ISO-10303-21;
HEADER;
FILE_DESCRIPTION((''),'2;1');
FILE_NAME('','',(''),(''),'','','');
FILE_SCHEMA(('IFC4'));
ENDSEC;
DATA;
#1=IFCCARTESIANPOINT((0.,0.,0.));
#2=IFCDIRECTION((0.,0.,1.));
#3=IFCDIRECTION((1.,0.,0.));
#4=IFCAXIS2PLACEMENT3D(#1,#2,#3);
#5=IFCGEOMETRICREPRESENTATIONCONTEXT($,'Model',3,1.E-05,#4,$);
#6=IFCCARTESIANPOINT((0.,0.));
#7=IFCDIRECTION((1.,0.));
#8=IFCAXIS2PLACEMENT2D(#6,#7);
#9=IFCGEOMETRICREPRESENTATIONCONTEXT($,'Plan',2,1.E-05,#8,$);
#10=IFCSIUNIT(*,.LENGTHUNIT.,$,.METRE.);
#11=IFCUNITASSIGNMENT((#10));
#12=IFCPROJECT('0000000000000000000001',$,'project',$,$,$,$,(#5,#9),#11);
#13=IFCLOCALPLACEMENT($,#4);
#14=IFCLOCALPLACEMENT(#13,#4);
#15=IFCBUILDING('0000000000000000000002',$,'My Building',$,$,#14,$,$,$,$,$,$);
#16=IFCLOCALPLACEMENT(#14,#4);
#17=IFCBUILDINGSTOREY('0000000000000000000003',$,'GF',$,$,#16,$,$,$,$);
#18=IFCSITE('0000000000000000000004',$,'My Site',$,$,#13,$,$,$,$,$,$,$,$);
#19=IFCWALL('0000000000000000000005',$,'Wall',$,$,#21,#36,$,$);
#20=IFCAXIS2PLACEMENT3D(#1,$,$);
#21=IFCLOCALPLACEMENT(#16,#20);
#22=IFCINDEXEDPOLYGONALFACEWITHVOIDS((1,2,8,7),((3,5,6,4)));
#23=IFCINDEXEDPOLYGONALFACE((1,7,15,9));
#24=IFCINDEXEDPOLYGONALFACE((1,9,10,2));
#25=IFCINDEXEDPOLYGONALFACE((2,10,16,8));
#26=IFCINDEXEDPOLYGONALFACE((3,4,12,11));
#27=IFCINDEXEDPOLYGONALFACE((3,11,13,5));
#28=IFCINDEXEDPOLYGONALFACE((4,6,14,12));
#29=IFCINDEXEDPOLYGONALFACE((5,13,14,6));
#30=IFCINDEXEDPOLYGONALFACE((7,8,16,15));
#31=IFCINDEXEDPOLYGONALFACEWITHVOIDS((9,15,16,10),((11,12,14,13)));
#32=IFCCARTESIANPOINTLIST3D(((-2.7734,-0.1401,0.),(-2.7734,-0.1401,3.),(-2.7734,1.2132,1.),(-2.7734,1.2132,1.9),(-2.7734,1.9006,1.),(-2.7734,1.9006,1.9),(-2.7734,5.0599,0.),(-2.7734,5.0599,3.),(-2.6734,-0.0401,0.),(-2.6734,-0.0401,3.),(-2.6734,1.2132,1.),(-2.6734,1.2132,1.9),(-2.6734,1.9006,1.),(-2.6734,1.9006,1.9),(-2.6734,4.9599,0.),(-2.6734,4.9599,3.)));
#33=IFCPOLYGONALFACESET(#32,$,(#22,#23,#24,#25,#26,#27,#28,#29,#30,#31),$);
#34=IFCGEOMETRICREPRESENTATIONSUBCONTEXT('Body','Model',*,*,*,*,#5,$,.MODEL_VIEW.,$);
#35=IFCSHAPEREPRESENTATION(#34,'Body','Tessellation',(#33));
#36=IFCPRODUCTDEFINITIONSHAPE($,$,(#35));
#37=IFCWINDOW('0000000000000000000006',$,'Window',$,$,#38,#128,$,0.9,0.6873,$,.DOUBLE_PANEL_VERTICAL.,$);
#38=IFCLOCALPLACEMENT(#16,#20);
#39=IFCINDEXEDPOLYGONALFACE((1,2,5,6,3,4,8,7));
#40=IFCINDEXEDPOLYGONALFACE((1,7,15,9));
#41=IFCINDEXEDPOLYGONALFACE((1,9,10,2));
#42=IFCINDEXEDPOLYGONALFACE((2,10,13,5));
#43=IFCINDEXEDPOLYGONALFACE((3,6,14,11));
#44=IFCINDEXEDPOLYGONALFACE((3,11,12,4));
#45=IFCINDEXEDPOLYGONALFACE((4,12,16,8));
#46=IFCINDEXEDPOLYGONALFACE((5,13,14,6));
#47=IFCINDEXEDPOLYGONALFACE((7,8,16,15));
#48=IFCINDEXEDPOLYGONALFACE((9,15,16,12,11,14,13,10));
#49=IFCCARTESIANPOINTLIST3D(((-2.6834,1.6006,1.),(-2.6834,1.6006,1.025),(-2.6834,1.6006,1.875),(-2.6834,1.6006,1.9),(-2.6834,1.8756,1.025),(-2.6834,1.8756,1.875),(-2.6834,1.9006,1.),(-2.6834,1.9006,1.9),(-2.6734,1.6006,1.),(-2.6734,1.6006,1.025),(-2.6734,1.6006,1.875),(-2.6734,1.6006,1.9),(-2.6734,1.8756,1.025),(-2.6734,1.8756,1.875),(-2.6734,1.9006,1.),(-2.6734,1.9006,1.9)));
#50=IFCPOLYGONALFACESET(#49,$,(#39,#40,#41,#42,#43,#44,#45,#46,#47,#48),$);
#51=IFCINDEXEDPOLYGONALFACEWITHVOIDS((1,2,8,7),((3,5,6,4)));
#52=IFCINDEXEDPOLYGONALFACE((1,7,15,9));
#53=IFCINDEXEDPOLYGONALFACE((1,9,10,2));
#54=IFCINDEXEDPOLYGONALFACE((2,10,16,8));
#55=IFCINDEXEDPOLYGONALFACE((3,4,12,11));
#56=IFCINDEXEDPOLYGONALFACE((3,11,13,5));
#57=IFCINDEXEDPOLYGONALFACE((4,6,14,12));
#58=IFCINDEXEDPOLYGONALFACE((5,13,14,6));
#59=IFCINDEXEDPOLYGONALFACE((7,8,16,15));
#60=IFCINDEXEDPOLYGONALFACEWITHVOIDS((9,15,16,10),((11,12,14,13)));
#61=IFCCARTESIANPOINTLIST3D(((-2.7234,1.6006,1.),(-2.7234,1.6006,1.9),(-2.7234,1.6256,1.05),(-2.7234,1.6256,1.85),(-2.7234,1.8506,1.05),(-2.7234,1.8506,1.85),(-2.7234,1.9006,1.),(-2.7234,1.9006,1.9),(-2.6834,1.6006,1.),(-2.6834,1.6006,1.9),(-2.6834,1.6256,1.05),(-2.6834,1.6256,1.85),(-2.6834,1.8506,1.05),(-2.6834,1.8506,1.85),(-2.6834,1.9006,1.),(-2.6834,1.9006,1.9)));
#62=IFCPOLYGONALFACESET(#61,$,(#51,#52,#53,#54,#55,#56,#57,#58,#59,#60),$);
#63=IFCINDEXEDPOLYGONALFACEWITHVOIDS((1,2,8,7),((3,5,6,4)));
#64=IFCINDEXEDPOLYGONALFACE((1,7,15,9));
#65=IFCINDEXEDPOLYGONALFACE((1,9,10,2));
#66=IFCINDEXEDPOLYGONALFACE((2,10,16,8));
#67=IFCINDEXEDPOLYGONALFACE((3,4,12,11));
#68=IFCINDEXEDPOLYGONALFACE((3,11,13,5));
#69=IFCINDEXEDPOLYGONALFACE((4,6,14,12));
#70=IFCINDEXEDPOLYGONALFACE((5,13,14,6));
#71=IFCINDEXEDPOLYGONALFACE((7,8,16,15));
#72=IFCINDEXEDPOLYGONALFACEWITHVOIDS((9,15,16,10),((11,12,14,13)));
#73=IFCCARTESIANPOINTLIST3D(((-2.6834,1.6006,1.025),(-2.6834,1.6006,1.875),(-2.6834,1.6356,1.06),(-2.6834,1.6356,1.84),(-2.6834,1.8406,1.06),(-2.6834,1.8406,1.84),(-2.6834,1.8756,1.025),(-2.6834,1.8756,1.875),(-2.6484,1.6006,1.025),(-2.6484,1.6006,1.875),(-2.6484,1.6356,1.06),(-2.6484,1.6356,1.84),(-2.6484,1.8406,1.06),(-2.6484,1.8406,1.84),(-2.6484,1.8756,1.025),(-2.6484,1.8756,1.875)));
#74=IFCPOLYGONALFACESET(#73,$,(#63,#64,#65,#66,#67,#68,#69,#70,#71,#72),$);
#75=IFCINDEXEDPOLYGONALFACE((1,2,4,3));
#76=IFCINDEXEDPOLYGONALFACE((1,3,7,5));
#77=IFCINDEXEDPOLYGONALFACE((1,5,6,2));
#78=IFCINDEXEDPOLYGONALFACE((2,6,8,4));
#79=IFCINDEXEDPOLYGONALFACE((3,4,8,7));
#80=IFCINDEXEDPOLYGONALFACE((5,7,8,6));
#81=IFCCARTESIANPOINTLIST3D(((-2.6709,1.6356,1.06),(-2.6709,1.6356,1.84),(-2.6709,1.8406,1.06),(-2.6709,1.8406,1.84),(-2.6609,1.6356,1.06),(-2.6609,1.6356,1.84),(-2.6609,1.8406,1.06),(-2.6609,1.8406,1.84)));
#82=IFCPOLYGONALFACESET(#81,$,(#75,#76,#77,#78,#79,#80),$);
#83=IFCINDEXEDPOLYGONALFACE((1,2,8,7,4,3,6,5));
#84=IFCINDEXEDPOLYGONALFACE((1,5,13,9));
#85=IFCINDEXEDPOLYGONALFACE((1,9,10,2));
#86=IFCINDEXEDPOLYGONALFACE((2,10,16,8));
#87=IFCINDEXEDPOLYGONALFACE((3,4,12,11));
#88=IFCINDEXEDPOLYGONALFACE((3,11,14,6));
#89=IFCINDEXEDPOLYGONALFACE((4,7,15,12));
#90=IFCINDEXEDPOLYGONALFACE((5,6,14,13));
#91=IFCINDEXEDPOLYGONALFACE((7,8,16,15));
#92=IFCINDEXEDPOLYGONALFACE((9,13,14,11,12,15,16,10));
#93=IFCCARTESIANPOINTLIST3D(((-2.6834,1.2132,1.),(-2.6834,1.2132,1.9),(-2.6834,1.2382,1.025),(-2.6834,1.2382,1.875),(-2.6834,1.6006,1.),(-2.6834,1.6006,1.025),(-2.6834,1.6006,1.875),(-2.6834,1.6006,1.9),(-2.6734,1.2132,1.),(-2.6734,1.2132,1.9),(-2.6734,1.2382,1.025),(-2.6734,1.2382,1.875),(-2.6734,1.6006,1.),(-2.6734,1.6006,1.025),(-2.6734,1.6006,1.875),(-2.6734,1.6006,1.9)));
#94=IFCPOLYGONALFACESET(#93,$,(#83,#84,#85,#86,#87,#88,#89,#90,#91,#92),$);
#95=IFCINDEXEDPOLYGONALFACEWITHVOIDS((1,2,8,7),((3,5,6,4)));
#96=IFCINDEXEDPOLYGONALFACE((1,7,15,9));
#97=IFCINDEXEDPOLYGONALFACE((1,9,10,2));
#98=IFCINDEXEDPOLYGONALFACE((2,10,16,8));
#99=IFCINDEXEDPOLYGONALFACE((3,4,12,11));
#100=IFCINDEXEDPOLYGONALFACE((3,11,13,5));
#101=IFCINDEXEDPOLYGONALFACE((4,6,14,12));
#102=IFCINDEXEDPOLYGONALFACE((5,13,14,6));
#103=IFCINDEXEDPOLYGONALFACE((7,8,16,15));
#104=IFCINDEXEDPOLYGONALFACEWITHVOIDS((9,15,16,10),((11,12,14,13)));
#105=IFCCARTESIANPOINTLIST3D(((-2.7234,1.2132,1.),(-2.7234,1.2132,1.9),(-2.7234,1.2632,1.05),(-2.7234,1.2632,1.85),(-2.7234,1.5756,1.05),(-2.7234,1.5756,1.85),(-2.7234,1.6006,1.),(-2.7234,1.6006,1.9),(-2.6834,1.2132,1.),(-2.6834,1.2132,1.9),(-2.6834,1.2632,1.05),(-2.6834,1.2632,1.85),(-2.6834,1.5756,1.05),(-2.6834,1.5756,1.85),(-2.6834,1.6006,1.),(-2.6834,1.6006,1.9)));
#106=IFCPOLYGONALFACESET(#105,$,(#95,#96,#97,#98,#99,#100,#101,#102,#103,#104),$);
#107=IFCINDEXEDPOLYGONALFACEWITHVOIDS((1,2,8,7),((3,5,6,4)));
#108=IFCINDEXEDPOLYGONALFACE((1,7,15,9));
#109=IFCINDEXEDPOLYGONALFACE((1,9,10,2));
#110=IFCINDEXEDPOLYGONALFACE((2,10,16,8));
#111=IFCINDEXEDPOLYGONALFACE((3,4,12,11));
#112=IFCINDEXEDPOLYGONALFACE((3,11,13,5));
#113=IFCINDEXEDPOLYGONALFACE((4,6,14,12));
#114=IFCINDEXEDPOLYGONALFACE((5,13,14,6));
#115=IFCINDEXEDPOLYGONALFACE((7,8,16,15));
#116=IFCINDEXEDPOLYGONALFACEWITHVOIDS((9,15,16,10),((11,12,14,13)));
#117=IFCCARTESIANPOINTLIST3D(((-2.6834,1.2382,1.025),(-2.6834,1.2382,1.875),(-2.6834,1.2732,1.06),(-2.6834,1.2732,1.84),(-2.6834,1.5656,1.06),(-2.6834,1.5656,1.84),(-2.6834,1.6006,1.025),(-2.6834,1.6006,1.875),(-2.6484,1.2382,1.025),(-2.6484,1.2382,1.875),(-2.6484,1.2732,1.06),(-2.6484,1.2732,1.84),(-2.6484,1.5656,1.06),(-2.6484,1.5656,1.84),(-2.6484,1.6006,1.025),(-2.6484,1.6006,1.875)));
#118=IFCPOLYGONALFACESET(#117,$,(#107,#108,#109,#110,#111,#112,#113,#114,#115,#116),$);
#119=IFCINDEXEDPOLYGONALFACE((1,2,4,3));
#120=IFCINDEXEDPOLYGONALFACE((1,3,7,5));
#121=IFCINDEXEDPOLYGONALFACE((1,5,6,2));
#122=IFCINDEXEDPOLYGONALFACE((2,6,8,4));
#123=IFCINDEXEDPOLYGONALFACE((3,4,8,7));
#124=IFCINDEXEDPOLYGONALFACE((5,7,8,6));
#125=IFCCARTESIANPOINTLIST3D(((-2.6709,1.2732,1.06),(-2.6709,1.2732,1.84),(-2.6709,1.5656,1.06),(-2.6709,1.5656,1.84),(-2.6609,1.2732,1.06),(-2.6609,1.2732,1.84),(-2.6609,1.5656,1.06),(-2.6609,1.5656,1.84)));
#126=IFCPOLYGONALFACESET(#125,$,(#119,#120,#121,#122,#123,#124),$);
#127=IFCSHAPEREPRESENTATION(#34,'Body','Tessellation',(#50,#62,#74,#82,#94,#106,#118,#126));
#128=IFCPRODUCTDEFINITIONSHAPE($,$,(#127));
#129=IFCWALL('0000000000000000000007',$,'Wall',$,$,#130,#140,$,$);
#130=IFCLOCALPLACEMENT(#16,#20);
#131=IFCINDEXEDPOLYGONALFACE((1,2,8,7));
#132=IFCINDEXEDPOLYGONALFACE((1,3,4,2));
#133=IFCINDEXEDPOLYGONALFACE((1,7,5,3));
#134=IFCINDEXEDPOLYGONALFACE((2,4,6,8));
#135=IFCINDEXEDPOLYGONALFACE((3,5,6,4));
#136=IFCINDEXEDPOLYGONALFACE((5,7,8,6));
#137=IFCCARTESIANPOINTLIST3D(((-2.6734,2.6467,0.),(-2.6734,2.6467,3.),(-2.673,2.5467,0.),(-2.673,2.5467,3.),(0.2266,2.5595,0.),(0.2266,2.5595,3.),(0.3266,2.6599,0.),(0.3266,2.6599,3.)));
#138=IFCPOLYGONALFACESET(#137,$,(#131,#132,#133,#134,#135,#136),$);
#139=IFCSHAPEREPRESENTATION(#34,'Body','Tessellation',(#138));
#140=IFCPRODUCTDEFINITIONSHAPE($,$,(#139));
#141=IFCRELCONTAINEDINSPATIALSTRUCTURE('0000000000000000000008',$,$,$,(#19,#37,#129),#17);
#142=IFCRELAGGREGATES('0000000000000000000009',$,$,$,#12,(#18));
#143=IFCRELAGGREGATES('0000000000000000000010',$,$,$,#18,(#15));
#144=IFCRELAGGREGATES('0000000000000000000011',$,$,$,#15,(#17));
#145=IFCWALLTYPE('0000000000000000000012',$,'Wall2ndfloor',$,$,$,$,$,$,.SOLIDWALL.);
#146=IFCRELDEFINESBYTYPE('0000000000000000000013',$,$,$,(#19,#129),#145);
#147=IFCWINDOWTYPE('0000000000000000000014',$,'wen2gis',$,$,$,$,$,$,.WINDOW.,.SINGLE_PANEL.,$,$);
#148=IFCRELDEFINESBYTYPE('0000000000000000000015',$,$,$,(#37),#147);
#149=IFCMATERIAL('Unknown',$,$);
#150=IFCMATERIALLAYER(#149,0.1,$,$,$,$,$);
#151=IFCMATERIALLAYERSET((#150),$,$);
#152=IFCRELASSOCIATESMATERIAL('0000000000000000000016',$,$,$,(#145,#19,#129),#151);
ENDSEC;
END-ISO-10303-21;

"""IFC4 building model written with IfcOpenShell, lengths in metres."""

from ifc_helpers import new_model, entity, si_unit, frame, origin_with_axes, origin_2d_with_axis, place, context, subcontext, project, spatial, line, indexed_curve, outline, extrude, shape, source, transform, mapped, material, layer, layer_set, layer_usage, type_object, type_shapes, element, fill, save


model = new_model("IFC4")

# Units and contexts
model_context = context("Model", 3, precision=1e-05, world=origin_with_axes())
plan_context = context("Plan", 2, precision=1e-05, world=origin_2d_with_axis())
body_context_1 = subcontext(model_context, "Body", "Model", "MODEL_VIEW")
body_context_2 = subcontext(plan_context, "Body", "Plan", "PLAN_VIEW")
ifc_project = project(units=[si_unit("LENGTHUNIT", "METRE")], contexts=[model_context, plan_context])

# Site, building, storey
site_placement = place(None, origin_with_axes())
site = spatial("IfcSite", under=ifc_project, at=site_placement, Name="My Site")
building_placement = place(site_placement, origin_with_axes())
building = spatial("IfcBuilding", under=site, at=building_placement, Name="My Building")
storey_placement = place(building_placement, origin_with_axes())
storey = spatial("IfcBuildingStorey", under=building, at=storey_placement, Name="GF")

# Shared definitions
ifc_material = material(Name="Unknown")

# Shared definitions
ifc_layer = layer(ifc_material, 0.1)
ifc_layer_set = layer_set([ifc_layer])
wall_type = type_object("IfcWallType", Name="Wall2ndfloor", PredefinedType="SOLIDWALL", material=ifc_layer_set)

# Wall, opening, window
ifc_layer_usage_1 = layer_usage(ifc_layer_set, "AXIS2", "POSITIVE", 0.0)
wall_1_placement = place(storey_placement, frame((-2.7734, 5.0599, 0.0), z_axis=(0.0, 0.0, 1.0), x_axis=(0.0, -1.0, 0.0)))
wall_1 = element("IfcWall", 1, at=wall_1_placement, inside=storey, type_object=wall_type, material=ifc_layer_usage_1, Name="Wall", context=body_context_1, shape_type="SweptSolid", body=[
    extrude(outline(indexed_curve([(0.0, 0.0), (0.1, 0.1), (5.1, 0.1), (5.2, 0.0)], segments=[line(1, 2, 3, 4, 1)])), origin_with_axes(), (0.0, 0.0, 1.0), 3.0),
])
shared_shape_1 = source(origin_with_axes(), body_context_1, "Body", "SweptSolid", [
    extrude(outline(indexed_curve([(0.0, 0.0), (0.6873, 0.0), (0.6873, 0.9), (0.0, 0.9)], segments=[line(1, 2, 3, 4, 1)])), frame((0.0, -0.6, 0.0), z_axis=(0.0, -1.0, 0.0), x_axis=(1.0, 0.0, 0.0)), (0.0, 0.0, -1.0), 1.2),
])
opening_1_placement = place(wall_1_placement, frame((3.1593, 0.0, 1.0), z_axis=(0.0, 0.0, 1.0), x_axis=(1.0, 0.0, 0.0)))
opening_1 = element("IfcOpeningElement", 2, at=opening_1_placement, cuts=wall_1, PredefinedType="OPENING", context=body_context_1, shape_type="MappedRepresentation", body=[
    mapped(shared_shape_1, transform((0.0, 0.0, 0.0), x_axis=(1.0, 0.0, 0.0), y_axis=(0.0, 1.0, 0.0), z_axis=(0.0, 0.0, 1.0), scale=1.0)),
])
window_type_1 = type_object("IfcWindowType", Name="wen2gis", PartitioningType="SINGLE_PANEL", PredefinedType="WINDOW")
shared_shape_2 = source(origin_with_axes(), body_context_1, "Body", "SweptSolid", [
    extrude(outline(indexed_curve([(0.3, 0.0), (0.0, 0.0), (0.0, 0.9), (0.3, 0.9), (0.3, 0.875), (0.025, 0.875), (0.025, 0.025), (0.3, 0.025)], segments=[line(1, 2, 3, 4, 5, 6, 7, 8, 1)])), frame((0.0, 0.09, 0.0), z_axis=(0.0, -1.0, 0.0), x_axis=(1.0, 0.0, 0.0)), (0.0, 0.0, -1.0), 0.01),
    extrude(outline(indexed_curve([(0.0, 0.0), (0.3, 0.0), (0.3, 0.9), (0.0, 0.9)], segments=[line(1, 2, 3, 4, 1)]), holes=[indexed_curve([(0.05, 0.05), (0.275, 0.05), (0.275, 0.85), (0.05, 0.85)], segments=[line(1, 2, 3, 4, 1)])]), frame((0.0, 0.05, 0.0), z_axis=(0.0, -1.0, 0.0), x_axis=(1.0, 0.0, 0.0)), (0.0, 0.0, -1.0), 0.04),
    extrude(outline(indexed_curve([(0.0, 0.0), (0.275, 0.0), (0.275, 0.85), (0.0, 0.85)], segments=[line(1, 2, 3, 4, 1)]), holes=[indexed_curve([(0.035, 0.035), (0.24, 0.035), (0.24, 0.815), (0.035, 0.815)], segments=[line(1, 2, 3, 4, 1)])]), frame((0.025, 0.09, 0.025), z_axis=(0.0, -1.0, 0.0), x_axis=(1.0, 0.0, 0.0)), (0.0, 0.0, -1.0), 0.035),
    extrude(outline(indexed_curve([(0.035, 0.035), (0.24, 0.035), (0.24, 0.815), (0.035, 0.815)], segments=[line(1, 2, 3, 4, 1)])), frame((0.025, 0.1025, 0.025), z_axis=(0.0, -1.0, 0.0), x_axis=(1.0, 0.0, 0.0)), (0.0, 0.0, -1.0), 0.01),
    extrude(outline(indexed_curve([(0.0, 0.9), (0.3873, 0.9), (0.3873, 0.0), (0.0, 0.0), (0.0, 0.025), (0.3623, 0.025), (0.3623, 0.875), (0.0, 0.875)], segments=[line(1, 2, 3, 4, 5, 6, 7, 8, 1)])), frame((0.3, 0.09, 0.0), z_axis=(0.0, -1.0, 0.0), x_axis=(1.0, 0.0, 0.0)), (0.0, 0.0, -1.0), 0.01),
    extrude(outline(indexed_curve([(0.0, 0.0), (0.3873, 0.0), (0.3873, 0.9), (0.0, 0.9)], segments=[line(1, 2, 3, 4, 1)]), holes=[indexed_curve([(0.025, 0.05), (0.3373, 0.05), (0.3373, 0.85), (0.025, 0.85)], segments=[line(1, 2, 3, 4, 1)])]), frame((0.3, 0.05, 0.0), z_axis=(0.0, -1.0, 0.0), x_axis=(1.0, 0.0, 0.0)), (0.0, 0.0, -1.0), 0.04),
    extrude(outline(indexed_curve([(0.0, 0.0), (0.3623, 0.0), (0.3623, 0.85), (0.0, 0.85)], segments=[line(1, 2, 3, 4, 1)]), holes=[indexed_curve([(0.035, 0.035), (0.3273, 0.035), (0.3273, 0.815), (0.035, 0.815)], segments=[line(1, 2, 3, 4, 1)])]), frame((0.3, 0.09, 0.025), z_axis=(0.0, -1.0, 0.0), x_axis=(1.0, 0.0, 0.0)), (0.0, 0.0, -1.0), 0.035),
    extrude(outline(indexed_curve([(0.035, 0.035), (0.3273, 0.035), (0.3273, 0.815), (0.035, 0.815)], segments=[line(1, 2, 3, 4, 1)])), frame((0.3, 0.1025, 0.025), z_axis=(0.0, -1.0, 0.0), x_axis=(1.0, 0.0, 0.0)), (0.0, 0.0, -1.0), 0.01),
])
shared_shape_3 = source(origin_with_axes(), body_context_2, "Body", "Curve2D", [
    entity("IfcIndexedPolyCurve", entity("IfcCartesianPointList2D", [[0.05, 0.05], [0.275, 0.05]])),
    entity("IfcIndexedPolyCurve", entity("IfcCartesianPointList2D", [[0.0, 0.1], [0.025, 0.1], [0.025, 0.09], [0.05, 0.09], [0.05, 0.05], [0.0, 0.05]]), [entity("IfcLineIndex", [1, 2, 3, 4, 5, 6, 1])]),
    entity("IfcIndexedPolyCurve", entity("IfcCartesianPointList2D", [[0.3, 0.1], [0.3, 0.1], [0.3, 0.09], [0.275, 0.09], [0.275, 0.05], [0.3, 0.05]])),
    entity("IfcIndexedPolyCurve", entity("IfcCartesianPointList2D", [[0.025, 0.09], [0.06, 0.09], [0.06, 0.125], [0.025, 0.125]]), [entity("IfcLineIndex", [1, 2, 3, 4, 1])]),
    entity("IfcIndexedPolyCurve", entity("IfcCartesianPointList2D", [[0.3, 0.09], [0.265, 0.09], [0.265, 0.125], [0.3, 0.125]]), [entity("IfcLineIndex", [1, 2, 3, 4, 1])]),
    entity("IfcIndexedPolyCurve", entity("IfcCartesianPointList2D", [[0.06, 0.09], [0.265, 0.09]])),
    entity("IfcIndexedPolyCurve", entity("IfcCartesianPointList2D", [[0.06, 0.125], [0.265, 0.125]])),
    entity("IfcIndexedPolyCurve", entity("IfcCartesianPointList2D", [[0.06, 0.1075], [0.265, 0.1075]])),
    entity("IfcIndexedPolyCurve", entity("IfcCartesianPointList2D", [[0.325, 0.05], [0.6373, 0.05]])),
    entity("IfcIndexedPolyCurve", entity("IfcCartesianPointList2D", [[0.3, 0.1], [0.3, 0.1], [0.3, 0.09], [0.325, 0.09], [0.325, 0.05], [0.3, 0.05]])),
    entity("IfcIndexedPolyCurve", entity("IfcCartesianPointList2D", [[0.6873, 0.1], [0.6623, 0.1], [0.6623, 0.09], [0.6373, 0.09], [0.6373, 0.05], [0.6873, 0.05]]), [entity("IfcLineIndex", [1, 2, 3, 4, 5, 6, 1])]),
    entity("IfcIndexedPolyCurve", entity("IfcCartesianPointList2D", [[0.3, 0.09], [0.335, 0.09], [0.335, 0.125], [0.3, 0.125]]), [entity("IfcLineIndex", [1, 2, 3, 4, 1])]),
    entity("IfcIndexedPolyCurve", entity("IfcCartesianPointList2D", [[0.6623, 0.09], [0.6273, 0.09], [0.6273, 0.125], [0.6623, 0.125]]), [entity("IfcLineIndex", [1, 2, 3, 4, 1])]),
    entity("IfcIndexedPolyCurve", entity("IfcCartesianPointList2D", [[0.335, 0.09], [0.6273, 0.09]])),
    entity("IfcIndexedPolyCurve", entity("IfcCartesianPointList2D", [[0.335, 0.125], [0.6273, 0.125]])),
    entity("IfcIndexedPolyCurve", entity("IfcCartesianPointList2D", [[0.335, 0.1075], [0.6273, 0.1075]])),
])
type_shapes(window_type_1, [shared_shape_2, shared_shape_3])
window_1_placement = place(opening_1_placement, frame((0.0, 0.0, 0.0), z_axis=(0.0, 0.0, 1.0), x_axis=(1.0, 0.0, 0.0)))
window_1 = element("IfcWindow", 3, at=window_1_placement, inside=storey, type_object=window_type_1, Name="Window", OverallHeight=0.9, OverallWidth=0.6873, PartitioningType="DOUBLE_PANEL_VERTICAL", shapes=[
    shape(body_context_1, "Body", "MappedRepresentation", [mapped(shared_shape_2, transform((0.0, 0.0, 0.0), x_axis=(1.0, 0.0, 0.0), y_axis=(0.0, 1.0, 0.0), z_axis=(0.0, 0.0, 1.0), scale=1.0))]),
    shape(body_context_2, "Body", "MappedRepresentation", [mapped(shared_shape_3, transform((0.0, 0.0, 0.0), x_axis=(1.0, 0.0, 0.0), y_axis=(0.0, 1.0, 0.0), z_axis=(0.0, 0.0, 1.0), scale=1.0))]),
])
fill(opening_1, window_1)

# Wall
ifc_layer_usage_2 = layer_usage(ifc_layer_set, "AXIS2", "POSITIVE", 0.0)
wall_2_placement = place(storey_placement, frame((0.3266, 2.6599, 0.0), z_axis=(0.0, 0.0, 1.0), x_axis=(-0.99999, -0.004387, 0.0)))
element("IfcWall", 4, at=wall_2_placement, inside=storey, type_object=wall_type, material=ifc_layer_usage_2, Name="Wall", context=body_context_1, shape_type="SweptSolid", body=[
    extrude(outline(indexed_curve([(0.0, 0.0), (0.1004, 0.1), (3.0, 0.1), (3.0, 0.0)], segments=[line(1, 2, 3, 4, 1)])), origin_with_axes(), (0.0, 0.0, 1.0), 3.0),
])

save(model, "model.ifc")
